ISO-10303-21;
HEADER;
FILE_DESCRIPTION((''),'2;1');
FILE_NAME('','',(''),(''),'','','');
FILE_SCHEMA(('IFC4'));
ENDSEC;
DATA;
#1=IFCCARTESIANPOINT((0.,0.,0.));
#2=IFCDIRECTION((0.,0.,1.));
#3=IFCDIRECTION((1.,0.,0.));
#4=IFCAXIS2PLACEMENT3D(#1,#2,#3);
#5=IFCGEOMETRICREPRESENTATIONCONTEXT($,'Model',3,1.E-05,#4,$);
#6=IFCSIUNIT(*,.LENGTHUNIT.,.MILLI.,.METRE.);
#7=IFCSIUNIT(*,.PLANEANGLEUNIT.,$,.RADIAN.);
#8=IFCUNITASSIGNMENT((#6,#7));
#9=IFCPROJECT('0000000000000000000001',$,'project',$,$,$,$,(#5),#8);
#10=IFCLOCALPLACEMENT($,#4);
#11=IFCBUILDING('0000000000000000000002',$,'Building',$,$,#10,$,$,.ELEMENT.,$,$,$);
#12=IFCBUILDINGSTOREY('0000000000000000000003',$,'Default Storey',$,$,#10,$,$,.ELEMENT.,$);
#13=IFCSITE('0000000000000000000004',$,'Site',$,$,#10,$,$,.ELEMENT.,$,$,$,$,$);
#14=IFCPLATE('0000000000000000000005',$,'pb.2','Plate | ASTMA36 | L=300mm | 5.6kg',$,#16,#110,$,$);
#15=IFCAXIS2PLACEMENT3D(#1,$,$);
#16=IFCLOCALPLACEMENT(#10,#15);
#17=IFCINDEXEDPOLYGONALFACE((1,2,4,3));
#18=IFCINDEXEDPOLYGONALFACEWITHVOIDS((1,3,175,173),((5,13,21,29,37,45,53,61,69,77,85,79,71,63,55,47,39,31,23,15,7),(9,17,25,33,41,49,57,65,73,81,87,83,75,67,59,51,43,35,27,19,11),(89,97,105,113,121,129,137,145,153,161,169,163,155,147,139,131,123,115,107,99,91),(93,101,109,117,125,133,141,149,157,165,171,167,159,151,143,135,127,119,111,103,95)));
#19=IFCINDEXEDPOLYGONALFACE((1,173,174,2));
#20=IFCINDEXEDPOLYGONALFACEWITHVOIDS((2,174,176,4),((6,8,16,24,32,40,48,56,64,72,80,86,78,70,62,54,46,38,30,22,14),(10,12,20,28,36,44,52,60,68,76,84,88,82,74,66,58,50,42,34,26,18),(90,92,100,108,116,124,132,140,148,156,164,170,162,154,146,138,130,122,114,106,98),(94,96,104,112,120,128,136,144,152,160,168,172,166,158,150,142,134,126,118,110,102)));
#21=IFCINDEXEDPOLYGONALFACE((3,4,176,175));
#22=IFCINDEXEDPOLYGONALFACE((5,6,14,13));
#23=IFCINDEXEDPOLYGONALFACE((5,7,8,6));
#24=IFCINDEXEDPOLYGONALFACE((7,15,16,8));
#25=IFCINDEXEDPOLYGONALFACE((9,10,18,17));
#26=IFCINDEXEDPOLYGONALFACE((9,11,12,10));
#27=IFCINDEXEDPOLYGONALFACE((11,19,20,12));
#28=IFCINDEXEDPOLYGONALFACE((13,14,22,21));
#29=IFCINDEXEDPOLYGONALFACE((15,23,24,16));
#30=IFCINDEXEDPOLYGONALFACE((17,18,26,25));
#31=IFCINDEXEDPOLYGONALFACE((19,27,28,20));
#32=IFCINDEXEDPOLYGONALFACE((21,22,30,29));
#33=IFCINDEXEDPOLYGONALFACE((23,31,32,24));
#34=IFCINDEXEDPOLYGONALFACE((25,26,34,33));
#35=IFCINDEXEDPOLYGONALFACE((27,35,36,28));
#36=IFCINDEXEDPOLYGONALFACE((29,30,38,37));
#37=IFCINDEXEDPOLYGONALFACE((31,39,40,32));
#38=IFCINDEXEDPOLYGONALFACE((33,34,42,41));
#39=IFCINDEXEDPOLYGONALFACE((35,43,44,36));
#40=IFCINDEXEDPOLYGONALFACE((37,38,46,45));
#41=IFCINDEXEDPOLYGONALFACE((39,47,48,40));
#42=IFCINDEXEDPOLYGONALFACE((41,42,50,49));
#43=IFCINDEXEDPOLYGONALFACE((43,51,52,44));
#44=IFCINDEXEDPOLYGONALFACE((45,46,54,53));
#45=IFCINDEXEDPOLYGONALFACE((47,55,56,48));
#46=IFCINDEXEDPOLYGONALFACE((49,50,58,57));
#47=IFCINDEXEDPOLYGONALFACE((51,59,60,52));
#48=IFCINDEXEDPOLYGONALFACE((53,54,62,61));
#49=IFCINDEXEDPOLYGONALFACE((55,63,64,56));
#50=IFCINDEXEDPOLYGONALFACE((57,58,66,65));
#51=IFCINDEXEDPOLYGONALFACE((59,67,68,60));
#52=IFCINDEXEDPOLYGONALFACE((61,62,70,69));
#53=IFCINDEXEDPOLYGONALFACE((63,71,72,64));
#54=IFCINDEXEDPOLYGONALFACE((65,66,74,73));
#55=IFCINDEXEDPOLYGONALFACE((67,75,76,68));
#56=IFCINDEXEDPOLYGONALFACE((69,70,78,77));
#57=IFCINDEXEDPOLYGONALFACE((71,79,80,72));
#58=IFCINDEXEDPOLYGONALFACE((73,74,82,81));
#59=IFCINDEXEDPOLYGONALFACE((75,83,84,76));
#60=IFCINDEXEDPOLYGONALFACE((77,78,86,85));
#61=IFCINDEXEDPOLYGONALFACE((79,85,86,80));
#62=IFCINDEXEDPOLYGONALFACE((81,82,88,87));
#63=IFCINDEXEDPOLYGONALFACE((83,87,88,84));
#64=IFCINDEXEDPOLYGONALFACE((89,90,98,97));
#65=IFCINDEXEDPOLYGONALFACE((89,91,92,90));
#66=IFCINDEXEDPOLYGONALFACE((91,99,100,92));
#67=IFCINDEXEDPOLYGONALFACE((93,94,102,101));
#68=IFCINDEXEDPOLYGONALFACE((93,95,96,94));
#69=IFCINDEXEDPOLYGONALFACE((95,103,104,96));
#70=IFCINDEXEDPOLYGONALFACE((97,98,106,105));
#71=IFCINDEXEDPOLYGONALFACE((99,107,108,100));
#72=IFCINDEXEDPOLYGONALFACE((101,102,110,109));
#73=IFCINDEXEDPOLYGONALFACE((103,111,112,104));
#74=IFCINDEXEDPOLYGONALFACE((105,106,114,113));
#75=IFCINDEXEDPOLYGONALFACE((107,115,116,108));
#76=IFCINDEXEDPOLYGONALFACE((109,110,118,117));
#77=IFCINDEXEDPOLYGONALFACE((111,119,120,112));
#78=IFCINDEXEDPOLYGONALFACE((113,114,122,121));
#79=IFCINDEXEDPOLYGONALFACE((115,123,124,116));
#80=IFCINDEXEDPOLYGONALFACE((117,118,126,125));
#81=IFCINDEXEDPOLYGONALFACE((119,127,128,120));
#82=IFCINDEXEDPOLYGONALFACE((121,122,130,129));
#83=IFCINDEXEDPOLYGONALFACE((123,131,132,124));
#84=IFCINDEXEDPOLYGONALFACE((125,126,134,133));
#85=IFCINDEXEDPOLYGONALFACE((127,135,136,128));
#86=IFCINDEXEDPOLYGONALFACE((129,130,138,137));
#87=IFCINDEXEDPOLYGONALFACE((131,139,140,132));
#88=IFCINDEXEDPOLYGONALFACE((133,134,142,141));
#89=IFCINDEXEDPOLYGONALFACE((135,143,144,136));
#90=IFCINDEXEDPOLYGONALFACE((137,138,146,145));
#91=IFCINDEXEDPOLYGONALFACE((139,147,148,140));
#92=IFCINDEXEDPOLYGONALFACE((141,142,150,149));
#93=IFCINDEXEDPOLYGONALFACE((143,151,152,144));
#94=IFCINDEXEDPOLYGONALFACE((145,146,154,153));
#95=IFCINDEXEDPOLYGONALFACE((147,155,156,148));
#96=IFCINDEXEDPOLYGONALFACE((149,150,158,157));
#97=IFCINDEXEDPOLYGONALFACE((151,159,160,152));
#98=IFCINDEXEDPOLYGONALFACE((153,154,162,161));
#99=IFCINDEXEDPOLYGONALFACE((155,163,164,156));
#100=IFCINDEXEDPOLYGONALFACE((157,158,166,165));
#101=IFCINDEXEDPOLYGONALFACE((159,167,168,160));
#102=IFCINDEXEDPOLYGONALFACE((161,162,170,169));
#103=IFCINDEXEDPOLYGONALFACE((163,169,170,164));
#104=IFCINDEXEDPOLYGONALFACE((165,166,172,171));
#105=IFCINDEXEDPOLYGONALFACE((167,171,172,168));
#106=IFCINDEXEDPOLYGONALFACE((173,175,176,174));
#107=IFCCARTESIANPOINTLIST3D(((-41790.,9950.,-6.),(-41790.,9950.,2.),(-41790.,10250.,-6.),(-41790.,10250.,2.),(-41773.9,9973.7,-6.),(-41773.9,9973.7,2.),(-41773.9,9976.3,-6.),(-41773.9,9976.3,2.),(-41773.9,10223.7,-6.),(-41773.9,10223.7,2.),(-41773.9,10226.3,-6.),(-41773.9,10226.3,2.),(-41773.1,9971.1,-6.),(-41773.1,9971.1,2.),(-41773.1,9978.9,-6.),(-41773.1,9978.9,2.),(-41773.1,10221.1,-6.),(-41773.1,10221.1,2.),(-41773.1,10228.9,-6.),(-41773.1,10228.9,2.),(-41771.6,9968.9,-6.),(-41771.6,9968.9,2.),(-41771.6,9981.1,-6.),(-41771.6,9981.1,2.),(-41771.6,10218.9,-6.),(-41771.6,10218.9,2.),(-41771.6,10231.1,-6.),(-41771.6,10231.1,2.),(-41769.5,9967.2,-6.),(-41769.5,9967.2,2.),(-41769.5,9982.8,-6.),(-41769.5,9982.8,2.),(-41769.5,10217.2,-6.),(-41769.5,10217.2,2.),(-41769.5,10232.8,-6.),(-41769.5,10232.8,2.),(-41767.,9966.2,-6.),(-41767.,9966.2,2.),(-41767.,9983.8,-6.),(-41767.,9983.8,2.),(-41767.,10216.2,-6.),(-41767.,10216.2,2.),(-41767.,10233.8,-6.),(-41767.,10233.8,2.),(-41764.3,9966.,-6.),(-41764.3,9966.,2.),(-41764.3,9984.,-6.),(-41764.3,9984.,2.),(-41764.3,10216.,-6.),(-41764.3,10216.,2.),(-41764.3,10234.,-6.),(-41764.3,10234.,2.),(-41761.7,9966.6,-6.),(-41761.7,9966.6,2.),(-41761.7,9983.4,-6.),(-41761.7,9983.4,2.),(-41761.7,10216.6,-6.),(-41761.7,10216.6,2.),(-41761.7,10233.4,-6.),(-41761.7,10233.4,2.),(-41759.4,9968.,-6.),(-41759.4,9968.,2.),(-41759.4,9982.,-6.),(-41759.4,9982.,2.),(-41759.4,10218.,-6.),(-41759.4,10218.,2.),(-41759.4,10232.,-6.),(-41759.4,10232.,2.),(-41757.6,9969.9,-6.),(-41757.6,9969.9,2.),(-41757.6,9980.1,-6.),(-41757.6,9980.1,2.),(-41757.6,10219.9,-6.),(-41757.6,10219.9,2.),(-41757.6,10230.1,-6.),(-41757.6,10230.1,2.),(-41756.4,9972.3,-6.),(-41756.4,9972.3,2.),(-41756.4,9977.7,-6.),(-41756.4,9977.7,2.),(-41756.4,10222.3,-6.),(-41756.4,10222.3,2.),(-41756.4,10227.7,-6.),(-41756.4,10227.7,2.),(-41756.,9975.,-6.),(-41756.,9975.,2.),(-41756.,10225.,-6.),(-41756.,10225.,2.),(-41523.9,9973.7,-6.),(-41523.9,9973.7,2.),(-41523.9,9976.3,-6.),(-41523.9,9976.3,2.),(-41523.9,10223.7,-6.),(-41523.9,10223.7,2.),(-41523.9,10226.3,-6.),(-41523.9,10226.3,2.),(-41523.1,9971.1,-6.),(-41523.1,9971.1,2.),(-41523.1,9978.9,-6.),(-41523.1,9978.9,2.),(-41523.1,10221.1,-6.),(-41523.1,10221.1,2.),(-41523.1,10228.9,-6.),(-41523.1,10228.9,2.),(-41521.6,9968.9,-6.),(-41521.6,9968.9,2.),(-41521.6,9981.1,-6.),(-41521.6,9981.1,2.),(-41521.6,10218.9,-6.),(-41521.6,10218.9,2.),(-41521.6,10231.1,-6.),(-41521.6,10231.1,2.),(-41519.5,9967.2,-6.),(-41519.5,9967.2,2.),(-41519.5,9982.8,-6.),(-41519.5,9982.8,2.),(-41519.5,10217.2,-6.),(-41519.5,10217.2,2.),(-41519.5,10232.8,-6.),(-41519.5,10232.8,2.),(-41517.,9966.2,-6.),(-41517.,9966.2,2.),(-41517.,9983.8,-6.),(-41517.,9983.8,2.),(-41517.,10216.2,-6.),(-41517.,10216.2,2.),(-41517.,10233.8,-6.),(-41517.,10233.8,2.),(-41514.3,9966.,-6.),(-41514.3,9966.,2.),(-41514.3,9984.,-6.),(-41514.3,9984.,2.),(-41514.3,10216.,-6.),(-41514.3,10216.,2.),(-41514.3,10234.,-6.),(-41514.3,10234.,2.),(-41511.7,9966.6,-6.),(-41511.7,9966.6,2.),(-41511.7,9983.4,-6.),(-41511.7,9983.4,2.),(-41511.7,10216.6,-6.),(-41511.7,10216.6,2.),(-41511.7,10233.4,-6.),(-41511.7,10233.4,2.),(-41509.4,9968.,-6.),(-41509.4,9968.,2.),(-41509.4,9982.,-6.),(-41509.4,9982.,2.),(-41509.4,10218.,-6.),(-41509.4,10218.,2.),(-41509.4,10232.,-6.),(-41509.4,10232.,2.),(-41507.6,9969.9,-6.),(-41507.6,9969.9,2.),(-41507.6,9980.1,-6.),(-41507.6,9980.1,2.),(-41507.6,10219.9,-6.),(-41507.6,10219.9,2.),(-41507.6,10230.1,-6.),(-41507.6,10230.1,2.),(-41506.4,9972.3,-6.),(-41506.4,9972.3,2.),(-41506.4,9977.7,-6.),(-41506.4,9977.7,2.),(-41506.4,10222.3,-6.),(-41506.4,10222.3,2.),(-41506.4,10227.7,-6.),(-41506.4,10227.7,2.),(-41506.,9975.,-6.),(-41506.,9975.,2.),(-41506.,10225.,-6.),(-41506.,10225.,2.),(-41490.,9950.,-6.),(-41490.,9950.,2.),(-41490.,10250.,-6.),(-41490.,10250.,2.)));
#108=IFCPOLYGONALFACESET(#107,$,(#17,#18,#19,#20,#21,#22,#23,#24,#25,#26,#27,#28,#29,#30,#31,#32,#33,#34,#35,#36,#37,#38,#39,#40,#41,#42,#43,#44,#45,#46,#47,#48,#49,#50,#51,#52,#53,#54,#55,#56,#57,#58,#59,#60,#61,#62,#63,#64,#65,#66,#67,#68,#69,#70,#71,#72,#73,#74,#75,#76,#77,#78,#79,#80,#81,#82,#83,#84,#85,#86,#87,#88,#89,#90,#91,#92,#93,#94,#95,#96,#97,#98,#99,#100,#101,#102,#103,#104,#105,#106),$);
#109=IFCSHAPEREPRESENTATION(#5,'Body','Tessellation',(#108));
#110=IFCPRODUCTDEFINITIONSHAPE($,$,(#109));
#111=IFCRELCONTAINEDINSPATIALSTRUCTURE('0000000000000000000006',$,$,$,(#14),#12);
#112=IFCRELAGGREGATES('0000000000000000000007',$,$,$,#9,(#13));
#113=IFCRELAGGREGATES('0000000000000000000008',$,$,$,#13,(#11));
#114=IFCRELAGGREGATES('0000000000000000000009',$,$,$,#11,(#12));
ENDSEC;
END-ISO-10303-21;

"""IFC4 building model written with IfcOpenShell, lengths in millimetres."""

from ifc_helpers import new_model, si_unit, frame, frame_2d, origin_with_axes, place, context, project, spatial, polyline, circle, outline, extrude, source, transform, mapped, element, save


model = new_model("IFC4")

# Units and contexts
model_context = context("Model", 3, precision=1e-05, world=origin_with_axes())
ifc_project = project(units=[si_unit("LENGTHUNIT", "METRE", prefix="MILLI"), si_unit("PLANEANGLEUNIT", "RADIAN")], contexts=[model_context])

# Site, building, storey
placement = place(None, origin_with_axes())
site = spatial("IfcSite", under=ifc_project, at=placement, Name="Site", CompositionType="ELEMENT")
building = spatial("IfcBuilding", under=site, at=placement, Name="Building", CompositionType="ELEMENT")
storey = spatial("IfcBuildingStorey", under=building, at=placement, Name="Default Storey", CompositionType="ELEMENT")

# Plate, openings
shared_shape = source(origin_with_axes(), model_context, "Body", "SweptSolid", [
    extrude(outline(polyline([(-150.0, 150.0), (-150.0, -150.0), (150.0, -150.0), (150.0, 150.0), (-150.0, 150.0)])), origin_with_axes(), (0.0, 0.0, 1.0), 8.0),
])
plate_placement = place(placement, frame((-41640.0, 10100.0, -6.0), z_axis=(0.0, 0.0, 1.0), x_axis=(1.0, 0.0, 0.0)))
plate = element("IfcPlate", 1, at=plate_placement, inside=storey, Name="pb.2", Description="Plate | ASTMA36 | L=300mm | 5.6kg", context=model_context, shape_type="MappedRepresentation", body=[
    mapped(shared_shape, transform((0.0, 0.0, 0.0), scale=1.0)),
])
opening_1_placement = place(plate_placement, frame((0.0, 0.0, -0.5), z_axis=(0.0, 0.0, 1.0), x_axis=(1.0, 0.0, 0.0)))
element("IfcOpeningElement", 2, at=opening_1_placement, cuts=plate, PredefinedType="OPENING", context=model_context, shape_type="SweptSolid", body=[
    extrude(circle(Radius=9.0, at=frame_2d((125.0, 125.0))), origin_with_axes(), (0.0, 0.0, 1.0), 9.0),
])
opening_2_placement = place(plate_placement, frame((0.0, 0.0, -0.5), z_axis=(0.0, 0.0, 1.0), x_axis=(1.0, 0.0, 0.0)))
element("IfcOpeningElement", 3, at=opening_2_placement, cuts=plate, PredefinedType="OPENING", context=model_context, shape_type="SweptSolid", body=[
    extrude(circle(Radius=9.0, at=frame_2d((-125.0, 125.0))), origin_with_axes(), (0.0, 0.0, 1.0), 9.0),
])
opening_3_placement = place(plate_placement, frame((0.0, 0.0, -0.5), z_axis=(0.0, 0.0, 1.0), x_axis=(1.0, 0.0, 0.0)))
element("IfcOpeningElement", 4, at=opening_3_placement, cuts=plate, PredefinedType="OPENING", context=model_context, shape_type="SweptSolid", body=[
    extrude(circle(Radius=9.0, at=frame_2d((125.0, -125.0))), origin_with_axes(), (0.0, 0.0, 1.0), 9.0),
])
opening_4_placement = place(plate_placement, frame((0.0, 0.0, -0.5), z_axis=(0.0, 0.0, 1.0), x_axis=(1.0, 0.0, 0.0)))
element("IfcOpeningElement", 5, at=opening_4_placement, cuts=plate, PredefinedType="OPENING", context=model_context, shape_type="SweptSolid", body=[
    extrude(circle(Radius=9.0, at=frame_2d((-125.0, -125.0))), origin_with_axes(), (0.0, 0.0, 1.0), 9.0),
])

save(model, "model.ifc")
